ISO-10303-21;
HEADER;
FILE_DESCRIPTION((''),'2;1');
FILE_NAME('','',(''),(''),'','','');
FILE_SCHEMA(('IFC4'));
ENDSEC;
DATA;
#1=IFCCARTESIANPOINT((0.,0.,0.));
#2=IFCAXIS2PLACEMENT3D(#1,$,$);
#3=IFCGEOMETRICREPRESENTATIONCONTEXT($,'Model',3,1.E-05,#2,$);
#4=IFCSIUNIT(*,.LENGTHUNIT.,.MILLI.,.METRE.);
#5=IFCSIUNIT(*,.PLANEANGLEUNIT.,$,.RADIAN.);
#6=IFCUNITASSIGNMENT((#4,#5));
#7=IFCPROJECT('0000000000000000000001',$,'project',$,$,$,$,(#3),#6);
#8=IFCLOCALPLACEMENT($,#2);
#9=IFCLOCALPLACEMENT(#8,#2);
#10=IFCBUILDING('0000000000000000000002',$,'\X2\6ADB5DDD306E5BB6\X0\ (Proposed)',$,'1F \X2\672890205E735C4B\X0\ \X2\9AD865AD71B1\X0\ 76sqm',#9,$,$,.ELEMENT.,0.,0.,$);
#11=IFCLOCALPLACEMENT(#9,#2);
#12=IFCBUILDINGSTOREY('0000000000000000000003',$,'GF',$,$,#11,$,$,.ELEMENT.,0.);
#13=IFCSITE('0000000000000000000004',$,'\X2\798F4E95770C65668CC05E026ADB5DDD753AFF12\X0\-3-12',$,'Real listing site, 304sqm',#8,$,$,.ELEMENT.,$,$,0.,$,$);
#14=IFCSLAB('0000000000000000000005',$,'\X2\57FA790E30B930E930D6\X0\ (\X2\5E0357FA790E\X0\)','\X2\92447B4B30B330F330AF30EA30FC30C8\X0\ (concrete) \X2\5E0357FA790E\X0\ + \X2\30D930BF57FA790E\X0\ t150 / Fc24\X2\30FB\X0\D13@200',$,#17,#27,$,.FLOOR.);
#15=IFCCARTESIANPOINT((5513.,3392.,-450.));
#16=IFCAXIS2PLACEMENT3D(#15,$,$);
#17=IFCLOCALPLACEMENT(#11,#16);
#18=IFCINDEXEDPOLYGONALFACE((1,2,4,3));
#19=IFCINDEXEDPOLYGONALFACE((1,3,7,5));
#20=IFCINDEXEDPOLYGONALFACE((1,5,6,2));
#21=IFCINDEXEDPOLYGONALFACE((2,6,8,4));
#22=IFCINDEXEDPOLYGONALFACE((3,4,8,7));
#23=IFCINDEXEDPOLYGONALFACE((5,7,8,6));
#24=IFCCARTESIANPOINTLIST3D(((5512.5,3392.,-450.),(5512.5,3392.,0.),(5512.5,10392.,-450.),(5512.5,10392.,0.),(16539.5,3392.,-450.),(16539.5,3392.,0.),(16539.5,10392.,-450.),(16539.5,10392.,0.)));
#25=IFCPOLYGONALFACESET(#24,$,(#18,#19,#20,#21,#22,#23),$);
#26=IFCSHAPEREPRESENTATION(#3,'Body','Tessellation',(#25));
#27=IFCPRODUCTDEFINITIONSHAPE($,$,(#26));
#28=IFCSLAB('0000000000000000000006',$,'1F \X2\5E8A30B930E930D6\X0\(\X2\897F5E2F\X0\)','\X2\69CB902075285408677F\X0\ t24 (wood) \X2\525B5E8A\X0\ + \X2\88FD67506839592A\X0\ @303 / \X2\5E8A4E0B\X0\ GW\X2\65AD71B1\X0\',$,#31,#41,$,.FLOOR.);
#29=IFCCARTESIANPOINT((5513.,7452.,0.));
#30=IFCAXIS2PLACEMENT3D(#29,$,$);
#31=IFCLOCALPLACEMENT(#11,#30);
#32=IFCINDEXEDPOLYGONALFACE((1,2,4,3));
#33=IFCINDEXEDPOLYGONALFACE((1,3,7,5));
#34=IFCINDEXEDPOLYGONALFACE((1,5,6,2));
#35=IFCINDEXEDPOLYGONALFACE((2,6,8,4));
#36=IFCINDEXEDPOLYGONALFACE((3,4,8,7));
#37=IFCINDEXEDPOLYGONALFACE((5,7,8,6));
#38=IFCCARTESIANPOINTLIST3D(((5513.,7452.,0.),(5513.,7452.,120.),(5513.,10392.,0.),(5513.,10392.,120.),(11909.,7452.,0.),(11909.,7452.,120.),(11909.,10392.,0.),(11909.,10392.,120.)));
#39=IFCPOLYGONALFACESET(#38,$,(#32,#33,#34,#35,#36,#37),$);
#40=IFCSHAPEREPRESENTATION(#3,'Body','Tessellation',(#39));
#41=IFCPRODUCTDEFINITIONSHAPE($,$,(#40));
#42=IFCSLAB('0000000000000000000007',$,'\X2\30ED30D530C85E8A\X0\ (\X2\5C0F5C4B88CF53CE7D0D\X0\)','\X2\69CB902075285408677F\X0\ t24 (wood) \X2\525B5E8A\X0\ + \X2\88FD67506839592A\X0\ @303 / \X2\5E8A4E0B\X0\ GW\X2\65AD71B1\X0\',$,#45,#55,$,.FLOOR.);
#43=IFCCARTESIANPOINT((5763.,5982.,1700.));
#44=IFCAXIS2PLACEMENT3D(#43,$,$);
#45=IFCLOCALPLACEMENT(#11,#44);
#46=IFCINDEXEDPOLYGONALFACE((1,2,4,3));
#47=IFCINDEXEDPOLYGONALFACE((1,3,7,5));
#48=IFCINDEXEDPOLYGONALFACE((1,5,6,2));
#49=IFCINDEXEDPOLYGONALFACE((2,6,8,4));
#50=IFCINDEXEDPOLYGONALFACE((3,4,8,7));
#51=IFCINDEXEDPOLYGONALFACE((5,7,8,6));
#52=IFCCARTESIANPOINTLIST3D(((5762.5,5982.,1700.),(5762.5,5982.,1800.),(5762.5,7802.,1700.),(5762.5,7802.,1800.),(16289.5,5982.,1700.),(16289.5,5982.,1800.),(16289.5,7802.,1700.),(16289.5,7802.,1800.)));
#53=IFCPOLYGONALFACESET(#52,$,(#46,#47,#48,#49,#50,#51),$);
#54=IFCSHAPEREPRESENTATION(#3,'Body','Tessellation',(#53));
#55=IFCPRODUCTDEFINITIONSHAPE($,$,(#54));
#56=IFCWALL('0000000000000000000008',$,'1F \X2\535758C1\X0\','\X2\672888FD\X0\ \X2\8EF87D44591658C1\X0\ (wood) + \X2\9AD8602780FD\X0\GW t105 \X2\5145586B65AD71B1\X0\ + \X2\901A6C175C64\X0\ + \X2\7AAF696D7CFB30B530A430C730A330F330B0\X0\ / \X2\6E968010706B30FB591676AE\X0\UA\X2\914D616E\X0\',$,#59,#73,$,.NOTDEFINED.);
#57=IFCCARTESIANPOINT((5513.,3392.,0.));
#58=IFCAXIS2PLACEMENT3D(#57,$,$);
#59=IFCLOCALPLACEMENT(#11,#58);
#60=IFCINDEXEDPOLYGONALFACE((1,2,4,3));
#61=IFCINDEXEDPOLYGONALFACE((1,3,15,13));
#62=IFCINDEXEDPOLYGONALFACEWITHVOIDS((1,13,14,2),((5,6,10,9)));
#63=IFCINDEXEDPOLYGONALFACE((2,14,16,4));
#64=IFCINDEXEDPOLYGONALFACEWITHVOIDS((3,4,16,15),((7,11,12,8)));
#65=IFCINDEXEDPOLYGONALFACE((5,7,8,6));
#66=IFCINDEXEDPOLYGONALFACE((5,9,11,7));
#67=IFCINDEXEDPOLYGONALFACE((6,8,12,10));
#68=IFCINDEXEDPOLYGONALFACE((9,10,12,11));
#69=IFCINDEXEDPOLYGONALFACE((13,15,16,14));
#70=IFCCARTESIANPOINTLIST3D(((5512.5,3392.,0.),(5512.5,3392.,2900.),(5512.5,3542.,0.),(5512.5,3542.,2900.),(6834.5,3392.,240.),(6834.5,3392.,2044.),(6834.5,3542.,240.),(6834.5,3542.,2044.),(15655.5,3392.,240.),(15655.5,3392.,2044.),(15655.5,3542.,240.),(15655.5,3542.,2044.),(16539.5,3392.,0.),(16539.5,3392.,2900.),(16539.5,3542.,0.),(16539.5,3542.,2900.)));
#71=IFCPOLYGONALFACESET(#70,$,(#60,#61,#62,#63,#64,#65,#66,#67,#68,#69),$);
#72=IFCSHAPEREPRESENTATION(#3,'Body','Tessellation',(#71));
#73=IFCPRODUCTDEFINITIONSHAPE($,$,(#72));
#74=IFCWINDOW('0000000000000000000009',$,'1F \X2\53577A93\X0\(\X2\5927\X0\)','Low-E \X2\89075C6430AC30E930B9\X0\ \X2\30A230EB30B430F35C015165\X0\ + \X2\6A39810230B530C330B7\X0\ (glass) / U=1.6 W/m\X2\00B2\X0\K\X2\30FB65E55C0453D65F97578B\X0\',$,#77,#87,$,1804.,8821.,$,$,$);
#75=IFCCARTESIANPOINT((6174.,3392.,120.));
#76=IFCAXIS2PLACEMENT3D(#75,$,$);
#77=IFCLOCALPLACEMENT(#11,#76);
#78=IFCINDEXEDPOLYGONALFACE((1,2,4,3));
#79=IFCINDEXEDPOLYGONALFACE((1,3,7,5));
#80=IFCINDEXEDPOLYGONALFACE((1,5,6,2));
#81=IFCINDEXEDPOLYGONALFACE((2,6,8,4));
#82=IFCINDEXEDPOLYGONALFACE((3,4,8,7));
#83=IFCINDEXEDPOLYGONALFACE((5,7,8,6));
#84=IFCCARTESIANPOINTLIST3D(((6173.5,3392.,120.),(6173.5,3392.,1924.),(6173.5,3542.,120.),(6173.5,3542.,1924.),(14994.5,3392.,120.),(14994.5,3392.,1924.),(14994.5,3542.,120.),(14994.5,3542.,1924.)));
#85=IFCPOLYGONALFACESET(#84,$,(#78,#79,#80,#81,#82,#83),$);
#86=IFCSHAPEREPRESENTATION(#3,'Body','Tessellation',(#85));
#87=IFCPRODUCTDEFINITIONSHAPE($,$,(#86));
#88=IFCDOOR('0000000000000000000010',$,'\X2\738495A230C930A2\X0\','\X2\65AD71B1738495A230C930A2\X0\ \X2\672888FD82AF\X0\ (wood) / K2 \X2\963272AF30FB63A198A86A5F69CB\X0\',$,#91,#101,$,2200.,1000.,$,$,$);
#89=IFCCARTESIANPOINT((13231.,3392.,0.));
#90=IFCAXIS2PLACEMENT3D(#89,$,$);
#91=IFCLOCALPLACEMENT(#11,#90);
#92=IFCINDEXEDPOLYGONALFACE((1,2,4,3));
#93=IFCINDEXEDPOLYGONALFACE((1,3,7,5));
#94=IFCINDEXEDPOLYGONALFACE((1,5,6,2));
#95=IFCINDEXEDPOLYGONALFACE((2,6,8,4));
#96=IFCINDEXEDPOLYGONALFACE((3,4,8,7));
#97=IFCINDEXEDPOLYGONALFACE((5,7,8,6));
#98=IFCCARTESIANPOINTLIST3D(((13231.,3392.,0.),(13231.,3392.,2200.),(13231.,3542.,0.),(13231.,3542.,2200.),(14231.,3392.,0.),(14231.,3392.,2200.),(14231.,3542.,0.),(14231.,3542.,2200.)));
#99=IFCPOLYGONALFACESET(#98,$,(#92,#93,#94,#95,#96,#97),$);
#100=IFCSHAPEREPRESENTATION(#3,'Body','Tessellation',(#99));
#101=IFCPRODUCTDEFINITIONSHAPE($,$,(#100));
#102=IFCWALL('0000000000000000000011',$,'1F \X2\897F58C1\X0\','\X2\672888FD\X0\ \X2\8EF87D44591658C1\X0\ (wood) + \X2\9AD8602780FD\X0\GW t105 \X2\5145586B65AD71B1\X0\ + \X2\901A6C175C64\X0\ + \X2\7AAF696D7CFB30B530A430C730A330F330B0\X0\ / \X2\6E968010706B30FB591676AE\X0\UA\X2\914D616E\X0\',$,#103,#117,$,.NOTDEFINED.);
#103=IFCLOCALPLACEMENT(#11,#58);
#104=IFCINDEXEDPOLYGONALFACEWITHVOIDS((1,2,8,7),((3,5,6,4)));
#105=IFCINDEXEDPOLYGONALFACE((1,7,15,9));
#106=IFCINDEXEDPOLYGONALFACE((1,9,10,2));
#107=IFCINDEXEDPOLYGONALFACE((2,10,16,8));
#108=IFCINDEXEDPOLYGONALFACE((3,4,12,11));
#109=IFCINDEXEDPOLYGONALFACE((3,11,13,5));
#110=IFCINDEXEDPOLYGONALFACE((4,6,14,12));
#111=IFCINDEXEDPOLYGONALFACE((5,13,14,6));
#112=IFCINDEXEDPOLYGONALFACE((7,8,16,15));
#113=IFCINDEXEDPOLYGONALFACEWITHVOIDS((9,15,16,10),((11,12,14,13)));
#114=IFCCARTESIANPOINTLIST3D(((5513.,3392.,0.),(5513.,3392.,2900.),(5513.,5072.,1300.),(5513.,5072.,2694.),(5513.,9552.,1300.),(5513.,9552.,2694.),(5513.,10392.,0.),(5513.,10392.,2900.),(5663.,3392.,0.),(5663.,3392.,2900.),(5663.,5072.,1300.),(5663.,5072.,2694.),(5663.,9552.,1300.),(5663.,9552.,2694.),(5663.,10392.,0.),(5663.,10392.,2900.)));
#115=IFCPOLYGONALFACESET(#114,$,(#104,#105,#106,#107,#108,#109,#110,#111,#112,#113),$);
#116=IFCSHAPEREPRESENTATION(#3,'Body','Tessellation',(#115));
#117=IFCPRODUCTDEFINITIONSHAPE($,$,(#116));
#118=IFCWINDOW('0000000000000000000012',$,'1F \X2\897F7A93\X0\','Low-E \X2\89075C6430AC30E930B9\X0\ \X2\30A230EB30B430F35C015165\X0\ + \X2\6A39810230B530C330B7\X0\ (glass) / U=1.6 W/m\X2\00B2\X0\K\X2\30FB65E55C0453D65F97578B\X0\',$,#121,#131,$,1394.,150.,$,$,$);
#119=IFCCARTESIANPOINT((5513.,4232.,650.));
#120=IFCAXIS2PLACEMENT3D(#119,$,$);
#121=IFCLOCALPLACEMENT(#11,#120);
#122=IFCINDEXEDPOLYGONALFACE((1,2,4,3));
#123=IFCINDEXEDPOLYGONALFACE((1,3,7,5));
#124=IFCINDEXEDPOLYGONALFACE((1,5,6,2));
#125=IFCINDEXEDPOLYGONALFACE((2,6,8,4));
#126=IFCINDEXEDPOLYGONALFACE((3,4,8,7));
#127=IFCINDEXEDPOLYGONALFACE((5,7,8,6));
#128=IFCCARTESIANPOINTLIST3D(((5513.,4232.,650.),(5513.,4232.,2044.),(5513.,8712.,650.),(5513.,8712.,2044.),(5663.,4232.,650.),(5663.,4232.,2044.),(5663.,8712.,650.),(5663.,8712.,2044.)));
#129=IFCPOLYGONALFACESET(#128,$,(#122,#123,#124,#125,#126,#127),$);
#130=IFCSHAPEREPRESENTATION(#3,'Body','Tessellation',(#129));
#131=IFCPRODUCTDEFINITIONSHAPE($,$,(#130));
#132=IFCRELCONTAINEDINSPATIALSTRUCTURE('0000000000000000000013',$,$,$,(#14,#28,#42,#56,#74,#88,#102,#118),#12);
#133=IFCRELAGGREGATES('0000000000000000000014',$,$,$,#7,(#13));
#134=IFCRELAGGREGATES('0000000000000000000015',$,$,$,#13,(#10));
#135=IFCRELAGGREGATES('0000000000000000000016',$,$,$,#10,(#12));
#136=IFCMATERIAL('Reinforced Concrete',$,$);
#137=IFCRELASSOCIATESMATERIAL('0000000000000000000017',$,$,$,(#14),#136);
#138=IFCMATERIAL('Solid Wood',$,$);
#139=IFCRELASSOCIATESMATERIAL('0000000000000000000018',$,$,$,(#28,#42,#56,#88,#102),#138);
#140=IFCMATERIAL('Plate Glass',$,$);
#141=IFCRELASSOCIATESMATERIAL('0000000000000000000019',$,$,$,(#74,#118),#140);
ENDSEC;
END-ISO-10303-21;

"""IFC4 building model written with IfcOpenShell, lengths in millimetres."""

from ifc_helpers import new_model, si_unit, frame, frame_2d, origin, place, context, project, spatial, rectangle, extrude, material, element, fill, save


model = new_model("IFC4")

# Units and contexts
model_context = context("Model", 3, precision=1e-05, world=origin())
ifc_project = project(units=[si_unit("LENGTHUNIT", "METRE", prefix="MILLI"), si_unit("PLANEANGLEUNIT", "RADIAN")], contexts=[model_context])

# Site, building, storey
site_placement = place(None, origin())
site = spatial("IfcSite", under=ifc_project, at=site_placement, Name="福井県敦賀市櫛川町２-3-12", ObjectType="Real listing site, 304sqm", CompositionType="ELEMENT", RefElevation=0.0)
building_placement = place(site_placement, origin())
building = spatial("IfcBuilding", under=site, at=building_placement, Name="櫛川の家 (Proposed)", ObjectType="1F 木造平屋 高断熱 76sqm", CompositionType="ELEMENT", ElevationOfRefHeight=0.0, ElevationOfTerrain=0.0)
storey_placement = place(building_placement, origin())
storey = spatial("IfcBuildingStorey", under=building, at=storey_placement, Name="GF", CompositionType="ELEMENT", Elevation=0.0)

# Slabs
ifc_material_1 = material(Name="Reinforced Concrete")
slab_1_placement = place(storey_placement, frame((5513.0, 3392.0, -450.0)))
element("IfcSlab", 1, at=slab_1_placement, inside=storey, material=ifc_material_1, Name="基礎スラブ (布基礎)", Description="鉄筋コンクリート (concrete) 布基礎 + ベタ基礎 t150 / Fc24・D13@200", PredefinedType="FLOOR", context=model_context, shape_type="SweptSolid", body=[
    extrude(rectangle(XDim=11027.0, YDim=7000.0, at=frame_2d((5513.0, 3500.0))), frame((5513.0, 3392.0, -450.0)), (0.0, 0.0, 1.0), 450.0),
])
ifc_material_2 = material(Name="Solid Wood")
slab_2_placement = place(storey_placement, frame((5513.0, 7452.0, 0.0)))
element("IfcSlab", 2, at=slab_2_placement, inside=storey, material=ifc_material_2, Name="1F 床スラブ(西帯)", Description="構造用合板 t24 (wood) 剛床 + 製材根太 @303 / 床下 GW断熱", PredefinedType="FLOOR", context=model_context, shape_type="SweptSolid", body=[
    extrude(rectangle(XDim=6396.0, YDim=2940.0, at=frame_2d((3198.0, 1470.0))), frame((5513.0, 7452.0, 0.0)), (0.0, 0.0, 1.0), 120.0),
])
slab_3_placement = place(storey_placement, frame((5763.0, 5982.0, 1700.0)))
element("IfcSlab", 3, at=slab_3_placement, inside=storey, material=ifc_material_2, Name="ロフト床 (小屋裏収納)", Description="構造用合板 t24 (wood) 剛床 + 製材根太 @303 / 床下 GW断熱", PredefinedType="FLOOR", context=model_context, shape_type="SweptSolid", body=[
    extrude(rectangle(XDim=10527.0, YDim=1820.0, at=frame_2d((5263.0, 910.0))), frame((5763.0, 5982.0, 1700.0)), (0.0, 0.0, 1.0), 100.0),
])

# Wall, openings, window, door
wall_1_placement = place(storey_placement, frame((5513.0, 3392.0, 0.0)))
wall_1 = element("IfcWall", 4, at=wall_1_placement, inside=storey, material=ifc_material_2, Name="1F 南壁", Description="木製 軸組外壁 (wood) + 高性能GW t105 充填断熱 + 通気層 + 窯業系サイディング / 準耐火・外皮UA配慮", PredefinedType="NOTDEFINED", context=model_context, shape_type="SweptSolid", body=[
    extrude(rectangle(XDim=11027.0, YDim=150.0, at=frame_2d((5513.0, 75.0))), frame((5513.0, 3392.0, 0.0)), (0.0, 0.0, 1.0), 2900.0),
])
opening_1_placement = place(storey_placement, frame((6174.0, 3392.0, 120.0)))
opening_1 = element("IfcOpeningElement", 5, at=opening_1_placement, cuts=wall_1, PredefinedType="NOTDEFINED", context=model_context, shape_type="SweptSolid", body=[
    extrude(rectangle(XDim=8821.0, YDim=150.0, at=frame_2d((4410.0, 75.0))), frame((6174.0, 3392.0, 120.0)), (0.0, 0.0, 1.0), 1804.0),
])
opening_2_placement = place(storey_placement, frame((13231.0, 3392.0, 0.0)))
opening_2 = element("IfcOpeningElement", 6, at=opening_2_placement, cuts=wall_1, PredefinedType="NOTDEFINED", context=model_context, shape_type="SweptSolid", body=[
    extrude(rectangle(XDim=1000.0, YDim=150.0, at=frame_2d((500.0, 75.0))), frame((13231.0, 3392.0, 0.0)), (0.0, 0.0, 1.0), 2200.0),
])
ifc_material_3 = material(Name="Plate Glass")
window_1_placement = place(storey_placement, frame((6174.0, 3392.0, 120.0)))
window_1 = element("IfcWindow", 7, at=window_1_placement, inside=storey, material=ifc_material_3, Name="1F 南窓(大)", Description="Low-E 複層ガラス アルゴン封入 + 樹脂サッシ (glass) / U=1.6 W/m²K・日射取得型", OverallHeight=1804.0, OverallWidth=8821.0, context=model_context, shape_type="SweptSolid", body=[
    extrude(rectangle(XDim=8821.0, YDim=150.0, at=frame_2d((4410.0, 75.0))), frame((6174.0, 3392.0, 120.0)), (0.0, 0.0, 1.0), 1804.0),
])
fill(opening_1, window_1)
door_1_placement = place(storey_placement, frame((13231.0, 3392.0, 0.0)))
door_1 = element("IfcDoor", 8, at=door_1_placement, inside=storey, material=ifc_material_2, Name="玄関ドア", Description="断熱玄関ドア 木製芯 (wood) / K2 防犯・採風機構", OverallHeight=2200.0, OverallWidth=1000.0, context=model_context, shape_type="SweptSolid", body=[
    extrude(rectangle(XDim=1000.0, YDim=150.0, at=frame_2d((500.0, 75.0))), frame((13231.0, 3392.0, 0.0)), (0.0, 0.0, 1.0), 2200.0),
])
fill(opening_2, door_1)

# Wall, opening, window
wall_2_placement = place(storey_placement, frame((5513.0, 3392.0, 0.0)))
wall_2 = element("IfcWall", 9, at=wall_2_placement, inside=storey, material=ifc_material_2, Name="1F 西壁", Description="木製 軸組外壁 (wood) + 高性能GW t105 充填断熱 + 通気層 + 窯業系サイディング / 準耐火・外皮UA配慮", PredefinedType="NOTDEFINED", context=model_context, shape_type="SweptSolid", body=[
    extrude(rectangle(XDim=150.0, YDim=7000.0, at=frame_2d((75.0, 3500.0))), frame((5513.0, 3392.0, 0.0)), (0.0, 0.0, 1.0), 2900.0),
])
opening_3_placement = place(storey_placement, frame((5513.0, 4232.0, 650.0)))
opening_3 = element("IfcOpeningElement", 10, at=opening_3_placement, cuts=wall_2, PredefinedType="NOTDEFINED", context=model_context, shape_type="SweptSolid", body=[
    extrude(rectangle(XDim=150.0, YDim=4480.0, at=frame_2d((75.0, 2240.0))), frame((5513.0, 4232.0, 650.0)), (0.0, 0.0, 1.0), 1394.0),
])
window_2_placement = place(storey_placement, frame((5513.0, 4232.0, 650.0)))
window_2 = element("IfcWindow", 11, at=window_2_placement, inside=storey, material=ifc_material_3, Name="1F 西窓", Description="Low-E 複層ガラス アルゴン封入 + 樹脂サッシ (glass) / U=1.6 W/m²K・日射取得型", OverallHeight=1394.0, OverallWidth=150.0, context=model_context, shape_type="SweptSolid", body=[
    extrude(rectangle(XDim=150.0, YDim=4480.0, at=frame_2d((75.0, 2240.0))), frame((5513.0, 4232.0, 650.0)), (0.0, 0.0, 1.0), 1394.0),
])
fill(opening_3, window_2)

save(model, "model.ifc")
